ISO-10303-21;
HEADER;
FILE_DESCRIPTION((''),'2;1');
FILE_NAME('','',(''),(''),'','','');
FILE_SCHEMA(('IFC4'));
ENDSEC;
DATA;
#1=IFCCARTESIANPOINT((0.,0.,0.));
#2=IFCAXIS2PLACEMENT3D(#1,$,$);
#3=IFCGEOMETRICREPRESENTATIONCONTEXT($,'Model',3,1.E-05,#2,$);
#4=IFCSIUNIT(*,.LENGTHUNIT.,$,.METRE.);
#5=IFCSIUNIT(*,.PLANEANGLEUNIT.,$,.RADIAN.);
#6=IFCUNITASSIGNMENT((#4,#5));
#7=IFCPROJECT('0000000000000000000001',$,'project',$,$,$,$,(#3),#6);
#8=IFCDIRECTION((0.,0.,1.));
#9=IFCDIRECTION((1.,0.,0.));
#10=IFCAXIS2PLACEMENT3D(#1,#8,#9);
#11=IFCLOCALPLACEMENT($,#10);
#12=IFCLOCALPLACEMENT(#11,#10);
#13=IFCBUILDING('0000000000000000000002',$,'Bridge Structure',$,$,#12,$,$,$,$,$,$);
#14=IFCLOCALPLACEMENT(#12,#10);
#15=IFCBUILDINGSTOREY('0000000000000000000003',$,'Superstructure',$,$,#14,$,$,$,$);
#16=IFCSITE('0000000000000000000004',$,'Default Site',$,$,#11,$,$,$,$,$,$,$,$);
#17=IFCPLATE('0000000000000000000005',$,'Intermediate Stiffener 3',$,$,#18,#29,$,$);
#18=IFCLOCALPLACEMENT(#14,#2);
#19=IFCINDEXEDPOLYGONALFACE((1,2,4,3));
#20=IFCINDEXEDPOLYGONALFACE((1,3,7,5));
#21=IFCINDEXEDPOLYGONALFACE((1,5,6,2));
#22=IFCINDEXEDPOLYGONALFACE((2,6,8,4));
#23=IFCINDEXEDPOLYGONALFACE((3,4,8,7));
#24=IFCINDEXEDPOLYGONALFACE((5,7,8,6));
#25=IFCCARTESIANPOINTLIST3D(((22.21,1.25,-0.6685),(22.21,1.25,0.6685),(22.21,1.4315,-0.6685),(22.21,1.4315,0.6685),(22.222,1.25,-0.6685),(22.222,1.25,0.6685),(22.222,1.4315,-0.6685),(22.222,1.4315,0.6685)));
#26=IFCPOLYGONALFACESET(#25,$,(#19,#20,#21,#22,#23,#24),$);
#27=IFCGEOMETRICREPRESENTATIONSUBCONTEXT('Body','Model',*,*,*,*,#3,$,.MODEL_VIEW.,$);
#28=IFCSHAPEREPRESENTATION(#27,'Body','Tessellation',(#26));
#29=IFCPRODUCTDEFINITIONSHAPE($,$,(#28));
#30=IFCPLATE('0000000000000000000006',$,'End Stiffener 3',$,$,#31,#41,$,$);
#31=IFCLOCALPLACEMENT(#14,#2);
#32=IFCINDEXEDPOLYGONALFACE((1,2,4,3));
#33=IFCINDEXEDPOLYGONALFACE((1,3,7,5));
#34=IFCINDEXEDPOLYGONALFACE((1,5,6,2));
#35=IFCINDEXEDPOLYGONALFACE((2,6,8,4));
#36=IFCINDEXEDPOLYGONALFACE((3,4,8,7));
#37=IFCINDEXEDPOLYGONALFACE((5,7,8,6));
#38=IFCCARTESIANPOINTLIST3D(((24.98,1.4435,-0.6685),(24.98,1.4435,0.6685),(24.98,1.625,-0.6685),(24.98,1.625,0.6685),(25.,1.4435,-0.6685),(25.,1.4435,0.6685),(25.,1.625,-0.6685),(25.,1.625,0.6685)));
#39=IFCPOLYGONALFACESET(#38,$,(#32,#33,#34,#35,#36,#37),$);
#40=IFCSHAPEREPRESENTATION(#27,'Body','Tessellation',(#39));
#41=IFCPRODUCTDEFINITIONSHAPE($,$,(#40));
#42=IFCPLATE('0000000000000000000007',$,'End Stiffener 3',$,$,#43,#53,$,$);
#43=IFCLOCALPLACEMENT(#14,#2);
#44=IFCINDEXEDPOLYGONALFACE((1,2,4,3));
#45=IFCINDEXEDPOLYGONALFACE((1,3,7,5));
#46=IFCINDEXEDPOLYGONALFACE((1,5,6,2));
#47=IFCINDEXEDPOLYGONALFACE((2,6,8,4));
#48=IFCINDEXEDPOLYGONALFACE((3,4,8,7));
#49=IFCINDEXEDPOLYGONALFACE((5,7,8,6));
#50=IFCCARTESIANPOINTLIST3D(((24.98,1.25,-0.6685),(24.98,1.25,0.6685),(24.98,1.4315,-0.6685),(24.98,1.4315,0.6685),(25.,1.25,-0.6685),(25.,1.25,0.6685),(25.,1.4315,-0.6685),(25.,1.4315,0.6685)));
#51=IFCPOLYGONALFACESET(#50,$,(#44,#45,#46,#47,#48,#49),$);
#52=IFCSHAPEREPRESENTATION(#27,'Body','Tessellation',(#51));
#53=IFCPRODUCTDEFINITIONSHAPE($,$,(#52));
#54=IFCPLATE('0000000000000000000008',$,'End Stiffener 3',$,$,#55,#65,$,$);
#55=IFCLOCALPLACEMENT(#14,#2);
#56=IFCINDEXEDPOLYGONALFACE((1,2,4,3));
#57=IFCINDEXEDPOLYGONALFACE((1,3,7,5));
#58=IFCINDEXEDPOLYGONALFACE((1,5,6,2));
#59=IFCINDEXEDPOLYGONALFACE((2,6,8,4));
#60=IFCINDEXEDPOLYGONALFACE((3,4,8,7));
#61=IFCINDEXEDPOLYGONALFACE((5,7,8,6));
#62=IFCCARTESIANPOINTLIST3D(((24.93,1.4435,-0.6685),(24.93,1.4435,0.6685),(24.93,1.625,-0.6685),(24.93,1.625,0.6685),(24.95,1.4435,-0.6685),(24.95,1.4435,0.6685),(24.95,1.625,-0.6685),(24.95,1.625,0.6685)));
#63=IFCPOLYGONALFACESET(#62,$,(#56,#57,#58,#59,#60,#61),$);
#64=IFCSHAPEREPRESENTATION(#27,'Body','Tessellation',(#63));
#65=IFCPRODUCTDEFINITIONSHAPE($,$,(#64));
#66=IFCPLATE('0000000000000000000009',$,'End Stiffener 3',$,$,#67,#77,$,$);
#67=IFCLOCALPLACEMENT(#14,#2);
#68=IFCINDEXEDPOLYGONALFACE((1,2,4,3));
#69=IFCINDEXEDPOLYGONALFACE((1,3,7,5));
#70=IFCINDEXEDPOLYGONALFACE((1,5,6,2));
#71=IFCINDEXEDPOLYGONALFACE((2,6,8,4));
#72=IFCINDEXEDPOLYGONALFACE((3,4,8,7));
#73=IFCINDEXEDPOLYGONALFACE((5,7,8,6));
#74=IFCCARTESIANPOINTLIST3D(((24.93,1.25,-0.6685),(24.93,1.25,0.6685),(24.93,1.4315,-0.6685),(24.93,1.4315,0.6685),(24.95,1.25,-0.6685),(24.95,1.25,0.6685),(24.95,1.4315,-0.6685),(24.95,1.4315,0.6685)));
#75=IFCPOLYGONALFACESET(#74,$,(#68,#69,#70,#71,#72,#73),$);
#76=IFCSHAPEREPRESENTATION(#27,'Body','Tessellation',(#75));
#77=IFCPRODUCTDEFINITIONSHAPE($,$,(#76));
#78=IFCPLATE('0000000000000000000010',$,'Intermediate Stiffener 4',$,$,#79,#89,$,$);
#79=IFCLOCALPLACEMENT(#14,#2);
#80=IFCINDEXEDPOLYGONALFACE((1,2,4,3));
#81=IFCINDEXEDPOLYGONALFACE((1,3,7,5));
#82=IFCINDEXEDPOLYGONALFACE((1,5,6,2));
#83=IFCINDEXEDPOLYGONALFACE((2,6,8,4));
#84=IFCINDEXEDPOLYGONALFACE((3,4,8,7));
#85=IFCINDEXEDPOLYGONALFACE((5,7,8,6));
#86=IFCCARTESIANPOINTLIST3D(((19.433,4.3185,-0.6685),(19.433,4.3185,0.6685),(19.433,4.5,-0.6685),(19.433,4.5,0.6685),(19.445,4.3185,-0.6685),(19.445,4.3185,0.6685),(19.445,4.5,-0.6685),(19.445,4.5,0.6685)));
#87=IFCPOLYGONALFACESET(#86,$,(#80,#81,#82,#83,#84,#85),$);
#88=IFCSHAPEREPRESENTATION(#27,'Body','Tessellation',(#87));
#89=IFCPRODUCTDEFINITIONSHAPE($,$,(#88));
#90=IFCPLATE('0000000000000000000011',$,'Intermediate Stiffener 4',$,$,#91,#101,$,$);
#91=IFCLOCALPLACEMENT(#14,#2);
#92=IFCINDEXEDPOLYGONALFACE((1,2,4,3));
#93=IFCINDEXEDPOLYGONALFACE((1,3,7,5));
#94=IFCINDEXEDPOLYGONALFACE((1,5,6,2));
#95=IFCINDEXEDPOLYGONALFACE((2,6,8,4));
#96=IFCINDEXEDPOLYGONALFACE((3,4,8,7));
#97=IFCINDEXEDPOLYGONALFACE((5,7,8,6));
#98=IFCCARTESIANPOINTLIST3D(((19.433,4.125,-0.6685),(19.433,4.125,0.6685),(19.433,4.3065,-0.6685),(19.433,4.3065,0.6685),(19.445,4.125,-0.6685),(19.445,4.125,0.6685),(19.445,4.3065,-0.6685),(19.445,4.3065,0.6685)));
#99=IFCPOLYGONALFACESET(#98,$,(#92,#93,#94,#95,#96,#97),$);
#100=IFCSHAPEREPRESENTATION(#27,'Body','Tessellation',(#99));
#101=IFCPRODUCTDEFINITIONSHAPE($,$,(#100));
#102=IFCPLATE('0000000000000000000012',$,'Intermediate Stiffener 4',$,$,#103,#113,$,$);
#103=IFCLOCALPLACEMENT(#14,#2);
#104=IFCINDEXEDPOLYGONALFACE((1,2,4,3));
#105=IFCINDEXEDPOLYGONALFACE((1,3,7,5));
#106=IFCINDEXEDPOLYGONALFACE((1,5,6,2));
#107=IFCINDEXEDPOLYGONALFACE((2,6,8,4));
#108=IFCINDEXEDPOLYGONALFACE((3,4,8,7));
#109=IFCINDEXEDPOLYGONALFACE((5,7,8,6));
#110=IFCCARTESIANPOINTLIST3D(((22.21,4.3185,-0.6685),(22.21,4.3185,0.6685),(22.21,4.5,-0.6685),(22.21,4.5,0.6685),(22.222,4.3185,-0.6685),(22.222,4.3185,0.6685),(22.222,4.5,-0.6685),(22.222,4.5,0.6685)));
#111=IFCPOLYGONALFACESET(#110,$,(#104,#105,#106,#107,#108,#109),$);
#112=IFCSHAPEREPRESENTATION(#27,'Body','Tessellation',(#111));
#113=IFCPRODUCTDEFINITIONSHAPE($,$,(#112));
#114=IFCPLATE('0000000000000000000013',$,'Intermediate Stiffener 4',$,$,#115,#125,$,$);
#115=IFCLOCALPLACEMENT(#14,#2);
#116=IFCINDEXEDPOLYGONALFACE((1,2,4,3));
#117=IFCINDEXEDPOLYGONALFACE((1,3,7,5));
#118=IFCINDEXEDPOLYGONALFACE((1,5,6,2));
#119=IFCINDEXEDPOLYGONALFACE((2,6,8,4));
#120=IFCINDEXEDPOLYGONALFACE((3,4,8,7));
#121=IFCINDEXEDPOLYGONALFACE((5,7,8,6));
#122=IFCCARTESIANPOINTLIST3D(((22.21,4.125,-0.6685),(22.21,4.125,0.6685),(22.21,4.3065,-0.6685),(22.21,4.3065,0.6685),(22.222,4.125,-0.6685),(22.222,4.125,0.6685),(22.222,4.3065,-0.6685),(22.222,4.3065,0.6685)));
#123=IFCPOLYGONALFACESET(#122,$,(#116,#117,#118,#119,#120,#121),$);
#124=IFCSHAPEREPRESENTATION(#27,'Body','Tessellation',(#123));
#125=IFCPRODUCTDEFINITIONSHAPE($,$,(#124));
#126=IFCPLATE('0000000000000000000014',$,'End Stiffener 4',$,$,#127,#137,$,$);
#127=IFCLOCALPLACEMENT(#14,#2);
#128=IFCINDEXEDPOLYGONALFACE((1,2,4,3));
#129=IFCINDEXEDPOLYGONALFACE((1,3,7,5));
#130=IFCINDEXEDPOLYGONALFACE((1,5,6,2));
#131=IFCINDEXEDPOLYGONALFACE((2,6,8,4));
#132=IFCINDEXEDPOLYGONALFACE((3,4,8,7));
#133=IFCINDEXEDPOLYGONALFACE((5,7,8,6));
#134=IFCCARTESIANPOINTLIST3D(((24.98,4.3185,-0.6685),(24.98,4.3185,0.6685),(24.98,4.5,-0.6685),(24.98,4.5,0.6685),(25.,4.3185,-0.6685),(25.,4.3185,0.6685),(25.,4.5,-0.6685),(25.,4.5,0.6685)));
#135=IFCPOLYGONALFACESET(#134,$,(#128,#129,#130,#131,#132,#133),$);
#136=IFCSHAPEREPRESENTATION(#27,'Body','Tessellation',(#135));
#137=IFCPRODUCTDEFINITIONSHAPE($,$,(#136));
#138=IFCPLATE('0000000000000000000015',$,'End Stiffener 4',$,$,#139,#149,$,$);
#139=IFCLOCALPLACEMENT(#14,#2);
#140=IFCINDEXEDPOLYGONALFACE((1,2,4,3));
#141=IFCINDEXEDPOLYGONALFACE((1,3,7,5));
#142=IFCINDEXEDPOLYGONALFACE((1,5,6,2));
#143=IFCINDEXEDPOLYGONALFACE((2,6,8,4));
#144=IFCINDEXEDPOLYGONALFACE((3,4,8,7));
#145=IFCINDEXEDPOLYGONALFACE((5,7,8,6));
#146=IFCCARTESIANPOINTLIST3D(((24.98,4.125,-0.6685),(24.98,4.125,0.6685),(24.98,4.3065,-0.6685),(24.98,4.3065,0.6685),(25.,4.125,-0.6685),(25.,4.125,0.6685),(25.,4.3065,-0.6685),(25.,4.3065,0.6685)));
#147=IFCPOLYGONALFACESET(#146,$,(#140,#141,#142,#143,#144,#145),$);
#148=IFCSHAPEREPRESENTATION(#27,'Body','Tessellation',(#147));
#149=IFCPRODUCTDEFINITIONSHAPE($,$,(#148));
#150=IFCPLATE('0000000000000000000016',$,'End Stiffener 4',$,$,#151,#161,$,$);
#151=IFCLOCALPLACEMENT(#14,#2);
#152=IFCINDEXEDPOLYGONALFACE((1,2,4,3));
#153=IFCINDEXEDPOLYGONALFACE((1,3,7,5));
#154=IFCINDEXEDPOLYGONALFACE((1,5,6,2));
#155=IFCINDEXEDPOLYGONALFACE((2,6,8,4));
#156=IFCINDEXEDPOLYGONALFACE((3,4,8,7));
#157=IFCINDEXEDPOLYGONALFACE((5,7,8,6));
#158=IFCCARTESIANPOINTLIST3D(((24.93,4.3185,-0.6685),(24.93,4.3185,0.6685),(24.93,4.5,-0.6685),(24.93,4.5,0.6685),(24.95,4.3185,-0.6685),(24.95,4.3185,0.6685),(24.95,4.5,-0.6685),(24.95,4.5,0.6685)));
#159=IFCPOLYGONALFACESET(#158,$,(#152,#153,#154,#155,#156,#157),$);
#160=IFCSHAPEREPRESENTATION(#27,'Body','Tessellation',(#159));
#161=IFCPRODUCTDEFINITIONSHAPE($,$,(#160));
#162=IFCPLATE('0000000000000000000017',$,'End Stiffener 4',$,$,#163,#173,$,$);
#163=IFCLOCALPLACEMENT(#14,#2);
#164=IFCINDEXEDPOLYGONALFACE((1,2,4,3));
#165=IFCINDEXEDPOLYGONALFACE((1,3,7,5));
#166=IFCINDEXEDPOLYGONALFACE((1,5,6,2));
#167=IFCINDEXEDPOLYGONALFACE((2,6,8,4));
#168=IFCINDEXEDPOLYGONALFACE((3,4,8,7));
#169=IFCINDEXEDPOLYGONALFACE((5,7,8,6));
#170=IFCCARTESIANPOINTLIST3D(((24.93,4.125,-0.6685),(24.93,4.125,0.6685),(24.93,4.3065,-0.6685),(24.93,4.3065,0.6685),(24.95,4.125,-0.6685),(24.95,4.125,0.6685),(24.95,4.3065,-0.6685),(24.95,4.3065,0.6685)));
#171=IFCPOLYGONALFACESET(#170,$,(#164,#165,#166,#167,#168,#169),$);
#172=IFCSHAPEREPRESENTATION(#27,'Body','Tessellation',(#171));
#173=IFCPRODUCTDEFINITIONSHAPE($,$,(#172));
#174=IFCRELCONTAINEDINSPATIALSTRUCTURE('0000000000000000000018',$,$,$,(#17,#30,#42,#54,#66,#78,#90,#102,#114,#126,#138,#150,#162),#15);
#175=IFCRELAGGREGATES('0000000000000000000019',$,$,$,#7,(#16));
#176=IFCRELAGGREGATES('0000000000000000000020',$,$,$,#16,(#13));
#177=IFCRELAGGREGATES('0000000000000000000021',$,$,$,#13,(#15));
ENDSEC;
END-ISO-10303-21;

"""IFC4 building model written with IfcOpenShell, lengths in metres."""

from ifc_helpers import new_model, si_unit, frame, origin, origin_with_axes, origin_2d_with_axis, place, context, subcontext, project, spatial, rectangle, extrude, element, save


model = new_model("IFC4")

# Units and contexts
model_context = context("Model", 3, precision=1e-05, world=origin())
body_context = subcontext(model_context, "Body", "Model", "MODEL_VIEW")
ifc_project = project(units=[si_unit("LENGTHUNIT", "METRE"), si_unit("PLANEANGLEUNIT", "RADIAN")], contexts=[model_context])

# Site, building, storey
site_placement = place(None, origin_with_axes())
site = spatial("IfcSite", under=ifc_project, at=site_placement, Name="Default Site")
building_placement = place(site_placement, origin_with_axes())
building = spatial("IfcBuilding", under=site, at=building_placement, Name="Bridge Structure")
storey_placement = place(building_placement, origin_with_axes())
storey = spatial("IfcBuildingStorey", under=building, at=storey_placement, Name="Superstructure")

# Plates
for number, where, z_axis, x_axis, name in (
    (1, (22.216, 1.3408, -0.6685), (0.0, 0.0, 1.0), (1.0, 0.0, 0.0), "Intermediate Stiffener 3"),
):
    element("IfcPlate", number, at=place(storey_placement, frame(where, z_axis=z_axis, x_axis=x_axis)), inside=storey, Name=name, context=body_context, shape_type="SweptSolid", body=[
        extrude(rectangle(XDim=0.012, YDim=0.1815, at=origin_2d_with_axis()), origin_with_axes(), (0.0, 0.0, 1.0), 1.337),
    ])
for number, where, z_axis, x_axis, name in (
    (2, (24.99, 1.5343, -0.6685), (0.0, 0.0, 1.0), (1.0, 0.0, 0.0), "End Stiffener 3"),
    (3, (24.99, 1.3408, -0.6685), (0.0, 0.0, 1.0), (1.0, 0.0, 0.0), "End Stiffener 3"),
    (4, (24.94, 1.5343, -0.6685), (0.0, 0.0, 1.0), (1.0, 0.0, 0.0), "End Stiffener 3"),
    (5, (24.94, 1.3408, -0.6685), (0.0, 0.0, 1.0), (1.0, 0.0, 0.0), "End Stiffener 3"),
):
    element("IfcPlate", number, at=place(storey_placement, frame(where, z_axis=z_axis, x_axis=x_axis)), inside=storey, Name=name, context=body_context, shape_type="SweptSolid", body=[
        extrude(rectangle(XDim=0.02, YDim=0.1815, at=origin_2d_with_axis()), origin_with_axes(), (0.0, 0.0, 1.0), 1.337),
    ])
for number, where, z_axis, x_axis, name in (
    (6, (19.439, 4.4093, -0.6685), (0.0, 0.0, 1.0), (1.0, 0.0, 0.0), "Intermediate Stiffener 4"),
    (7, (19.439, 4.2157, -0.6685), (0.0, 0.0, 1.0), (1.0, 0.0, 0.0), "Intermediate Stiffener 4"),
    (8, (22.216, 4.4093, -0.6685), (0.0, 0.0, 1.0), (1.0, 0.0, 0.0), "Intermediate Stiffener 4"),
    (9, (22.216, 4.2157, -0.6685), (0.0, 0.0, 1.0), (1.0, 0.0, 0.0), "Intermediate Stiffener 4"),
):
    element("IfcPlate", number, at=place(storey_placement, frame(where, z_axis=z_axis, x_axis=x_axis)), inside=storey, Name=name, context=body_context, shape_type="SweptSolid", body=[
        extrude(rectangle(XDim=0.012, YDim=0.1815, at=origin_2d_with_axis()), origin_with_axes(), (0.0, 0.0, 1.0), 1.337),
    ])
for number, where, z_axis, x_axis, name in (
    (10, (24.99, 4.4093, -0.6685), (0.0, 0.0, 1.0), (1.0, 0.0, 0.0), "End Stiffener 4"),
    (11, (24.99, 4.2157, -0.6685), (0.0, 0.0, 1.0), (1.0, 0.0, 0.0), "End Stiffener 4"),
    (12, (24.94, 4.4093, -0.6685), (0.0, 0.0, 1.0), (1.0, 0.0, 0.0), "End Stiffener 4"),
    (13, (24.94, 4.2157, -0.6685), (0.0, 0.0, 1.0), (1.0, 0.0, 0.0), "End Stiffener 4"),
):
    element("IfcPlate", number, at=place(storey_placement, frame(where, z_axis=z_axis, x_axis=x_axis)), inside=storey, Name=name, context=body_context, shape_type="SweptSolid", body=[
        extrude(rectangle(XDim=0.02, YDim=0.1815, at=origin_2d_with_axis()), origin_with_axes(), (0.0, 0.0, 1.0), 1.337),
    ])

save(model, "model.ifc")
